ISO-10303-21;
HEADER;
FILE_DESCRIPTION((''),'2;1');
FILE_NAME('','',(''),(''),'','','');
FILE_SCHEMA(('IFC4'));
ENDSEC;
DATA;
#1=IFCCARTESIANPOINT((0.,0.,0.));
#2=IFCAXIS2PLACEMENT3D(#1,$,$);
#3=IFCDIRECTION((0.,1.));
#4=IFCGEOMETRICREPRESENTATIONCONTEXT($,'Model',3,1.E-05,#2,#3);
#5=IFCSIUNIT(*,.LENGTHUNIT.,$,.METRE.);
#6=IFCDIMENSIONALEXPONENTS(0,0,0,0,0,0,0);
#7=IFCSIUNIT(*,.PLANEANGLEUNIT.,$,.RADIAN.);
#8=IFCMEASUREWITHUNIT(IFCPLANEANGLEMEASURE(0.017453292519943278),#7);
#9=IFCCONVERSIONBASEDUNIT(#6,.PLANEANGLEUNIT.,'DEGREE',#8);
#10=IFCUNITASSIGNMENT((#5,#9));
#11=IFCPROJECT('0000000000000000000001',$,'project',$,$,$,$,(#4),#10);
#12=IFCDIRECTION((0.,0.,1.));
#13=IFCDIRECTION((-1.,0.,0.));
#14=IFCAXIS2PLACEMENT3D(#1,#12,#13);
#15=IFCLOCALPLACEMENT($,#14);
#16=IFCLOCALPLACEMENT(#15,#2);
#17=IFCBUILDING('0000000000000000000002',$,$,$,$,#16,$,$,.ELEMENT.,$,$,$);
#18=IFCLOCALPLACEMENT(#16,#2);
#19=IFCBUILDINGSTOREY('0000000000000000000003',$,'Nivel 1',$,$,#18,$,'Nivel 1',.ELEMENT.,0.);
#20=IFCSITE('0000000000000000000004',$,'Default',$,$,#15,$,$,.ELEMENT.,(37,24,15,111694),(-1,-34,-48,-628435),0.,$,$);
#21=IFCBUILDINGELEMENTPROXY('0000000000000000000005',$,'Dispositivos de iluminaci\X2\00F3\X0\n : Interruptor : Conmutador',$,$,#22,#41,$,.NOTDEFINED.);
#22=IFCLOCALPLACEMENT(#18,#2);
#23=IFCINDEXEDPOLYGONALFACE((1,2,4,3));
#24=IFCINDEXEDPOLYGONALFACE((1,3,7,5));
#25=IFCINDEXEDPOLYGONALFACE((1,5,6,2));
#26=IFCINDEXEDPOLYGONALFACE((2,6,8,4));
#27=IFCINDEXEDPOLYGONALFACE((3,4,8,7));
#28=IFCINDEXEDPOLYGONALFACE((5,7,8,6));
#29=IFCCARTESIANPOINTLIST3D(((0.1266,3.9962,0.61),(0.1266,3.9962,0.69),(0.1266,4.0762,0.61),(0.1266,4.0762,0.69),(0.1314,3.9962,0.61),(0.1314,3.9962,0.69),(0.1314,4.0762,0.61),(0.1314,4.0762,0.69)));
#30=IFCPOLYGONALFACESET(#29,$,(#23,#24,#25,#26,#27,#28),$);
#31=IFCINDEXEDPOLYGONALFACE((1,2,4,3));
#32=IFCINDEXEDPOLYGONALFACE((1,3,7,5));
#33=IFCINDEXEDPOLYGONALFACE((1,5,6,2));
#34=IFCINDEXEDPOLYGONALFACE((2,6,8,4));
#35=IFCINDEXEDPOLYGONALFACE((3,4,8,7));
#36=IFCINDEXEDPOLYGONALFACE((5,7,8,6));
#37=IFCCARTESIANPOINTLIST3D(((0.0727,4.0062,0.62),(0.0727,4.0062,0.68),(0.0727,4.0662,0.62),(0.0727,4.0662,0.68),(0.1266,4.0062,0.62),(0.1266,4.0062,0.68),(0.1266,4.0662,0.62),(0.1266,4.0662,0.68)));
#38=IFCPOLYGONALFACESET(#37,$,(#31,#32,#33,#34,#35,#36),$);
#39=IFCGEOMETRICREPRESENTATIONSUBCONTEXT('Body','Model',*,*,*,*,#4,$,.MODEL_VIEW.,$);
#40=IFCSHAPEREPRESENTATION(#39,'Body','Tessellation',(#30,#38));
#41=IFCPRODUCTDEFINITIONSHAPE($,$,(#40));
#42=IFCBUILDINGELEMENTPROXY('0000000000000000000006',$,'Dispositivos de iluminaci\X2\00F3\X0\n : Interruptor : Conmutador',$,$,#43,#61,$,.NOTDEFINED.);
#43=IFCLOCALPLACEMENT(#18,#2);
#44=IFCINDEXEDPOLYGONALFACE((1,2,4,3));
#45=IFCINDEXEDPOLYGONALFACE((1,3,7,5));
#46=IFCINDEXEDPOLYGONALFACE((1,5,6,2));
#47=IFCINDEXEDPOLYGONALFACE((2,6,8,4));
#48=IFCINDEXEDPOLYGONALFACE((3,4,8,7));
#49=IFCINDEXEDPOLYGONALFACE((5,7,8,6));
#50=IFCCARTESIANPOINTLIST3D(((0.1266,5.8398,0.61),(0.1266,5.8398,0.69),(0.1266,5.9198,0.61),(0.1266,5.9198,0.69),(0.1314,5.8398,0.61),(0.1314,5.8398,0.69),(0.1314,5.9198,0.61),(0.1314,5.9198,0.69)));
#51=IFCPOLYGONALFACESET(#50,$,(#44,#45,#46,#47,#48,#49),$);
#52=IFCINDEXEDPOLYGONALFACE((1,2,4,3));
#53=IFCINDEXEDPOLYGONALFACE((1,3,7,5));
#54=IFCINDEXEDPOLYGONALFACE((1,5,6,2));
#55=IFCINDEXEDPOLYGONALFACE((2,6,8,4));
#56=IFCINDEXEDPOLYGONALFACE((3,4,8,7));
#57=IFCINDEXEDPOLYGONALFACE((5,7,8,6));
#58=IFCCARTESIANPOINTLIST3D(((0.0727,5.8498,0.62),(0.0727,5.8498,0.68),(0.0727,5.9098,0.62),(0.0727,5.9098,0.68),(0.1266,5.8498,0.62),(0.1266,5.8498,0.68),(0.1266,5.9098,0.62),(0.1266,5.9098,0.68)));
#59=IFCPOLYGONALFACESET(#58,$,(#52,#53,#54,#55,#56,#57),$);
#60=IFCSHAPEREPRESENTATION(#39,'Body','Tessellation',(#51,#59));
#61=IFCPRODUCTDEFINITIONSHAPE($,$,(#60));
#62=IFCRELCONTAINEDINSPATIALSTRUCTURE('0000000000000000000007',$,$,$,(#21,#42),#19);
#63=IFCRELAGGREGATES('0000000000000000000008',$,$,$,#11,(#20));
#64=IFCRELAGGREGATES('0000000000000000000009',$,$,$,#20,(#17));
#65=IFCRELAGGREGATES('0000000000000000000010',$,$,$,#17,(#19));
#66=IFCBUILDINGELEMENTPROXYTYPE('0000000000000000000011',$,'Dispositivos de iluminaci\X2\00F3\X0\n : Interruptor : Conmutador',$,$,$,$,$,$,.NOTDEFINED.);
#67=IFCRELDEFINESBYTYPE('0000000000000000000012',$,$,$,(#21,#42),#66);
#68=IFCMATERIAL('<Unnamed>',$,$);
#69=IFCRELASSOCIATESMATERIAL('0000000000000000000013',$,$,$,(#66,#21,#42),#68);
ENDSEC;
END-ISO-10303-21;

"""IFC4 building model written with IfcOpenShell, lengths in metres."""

from ifc_helpers import new_model, entity, si_unit, converted_unit, direction, frame, origin, place, context, subcontext, project, spatial, indexed_curve, outline, extrude, source, transform, mapped, material, type_object, type_shapes, element, save


model = new_model("IFC4")

# Units and contexts
model_context = context("Model", 3, precision=1e-05, world=origin(), true_north=direction((0.0, 1.0)))
body_context = subcontext(model_context, "Body", "Model", "MODEL_VIEW")
ifc_project = project(units=[si_unit("LENGTHUNIT", "METRE"), converted_unit("PLANEANGLEUNIT", "DEGREE", entity("IfcPlaneAngleMeasure", 0.017453292519943278), si_unit("PLANEANGLEUNIT", "RADIAN"), dimensions=[0, 0, 0, 0, 0, 0, 0])], contexts=[model_context])

# Site, building, storey
site_placement = place(None, frame((0.0, 0.0, 0.0), z_axis=(0.0, 0.0, 1.0), x_axis=(-1.0, 0.0, 0.0)))
site = spatial("IfcSite", under=ifc_project, at=site_placement, Name="Default", CompositionType="ELEMENT", RefLatitude=(37, 24, 15, 111694), RefLongitude=(-1, -34, -48, -628435), RefElevation=0.0)
building_placement = place(site_placement, origin())
building = spatial("IfcBuilding", under=site, at=building_placement, CompositionType="ELEMENT")
storey_placement = place(building_placement, origin())
storey = spatial("IfcBuildingStorey", under=building, at=storey_placement, Name="Nivel 1", LongName="Nivel 1", CompositionType="ELEMENT", Elevation=0.0)

# Shared definitions
ifc_material_1 = material(Name="<Unnamed>")

# Building element proxies
building_element_proxy_type_1 = type_object("IfcBuildingElementProxyType", Name="Dispositivos de iluminación : Interruptor : Conmutador", PredefinedType="NOTDEFINED", material=ifc_material_1)
shared_shape_1 = source(origin(), body_context, "Body", "SweptSolid", [
    extrude(outline(indexed_curve([(-0.04, -0.04), (0.04, -0.04), (0.04, 0.04), (-0.04, 0.04), (-0.04, -0.04)], self_intersect=False)), frame((0.0, 0.0, 0.0), z_axis=(0.0, 0.0, 1.0), x_axis=(0.0, -1.0, 0.0)), (0.0, 0.0, 1.0), 0.0048),
    extrude(outline(indexed_curve([(-0.03, -0.03), (0.03, -0.03), (0.03, 0.03), (-0.03, 0.03), (-0.03, -0.03)], self_intersect=False)), frame((0.0, 0.0, -0.054), z_axis=(0.0, 0.0, 1.0), x_axis=(-1.0, 0.0, 0.0)), (0.0, 0.0, 1.0), 0.054),
])
type_shapes(building_element_proxy_type_1, [shared_shape_1])
for number, where, z_axis, x_axis, name in (
    (1, (0.1266, 4.0362, 0.65), (1.0, 0.0, 0.0), (0.0, 1.0, 0.0), "Dispositivos de iluminación : Interruptor : Conmutador"),
    (2, (0.1266, 5.8798, 0.65), (1.0, 0.0, 0.0), (0.0, 1.0, 0.0), "Dispositivos de iluminación : Interruptor : Conmutador"),
):
    element("IfcBuildingElementProxy", number, at=place(storey_placement, frame(where, z_axis=z_axis, x_axis=x_axis)), inside=storey, type_object=building_element_proxy_type_1, material=ifc_material_1, Name=name, PredefinedType="NOTDEFINED", context=body_context, shape_type="MappedRepresentation", body=[
        mapped(shared_shape_1, transform((0.0, 0.0, 0.0), scale=1.0)),
    ])

save(model, "model.ifc")
